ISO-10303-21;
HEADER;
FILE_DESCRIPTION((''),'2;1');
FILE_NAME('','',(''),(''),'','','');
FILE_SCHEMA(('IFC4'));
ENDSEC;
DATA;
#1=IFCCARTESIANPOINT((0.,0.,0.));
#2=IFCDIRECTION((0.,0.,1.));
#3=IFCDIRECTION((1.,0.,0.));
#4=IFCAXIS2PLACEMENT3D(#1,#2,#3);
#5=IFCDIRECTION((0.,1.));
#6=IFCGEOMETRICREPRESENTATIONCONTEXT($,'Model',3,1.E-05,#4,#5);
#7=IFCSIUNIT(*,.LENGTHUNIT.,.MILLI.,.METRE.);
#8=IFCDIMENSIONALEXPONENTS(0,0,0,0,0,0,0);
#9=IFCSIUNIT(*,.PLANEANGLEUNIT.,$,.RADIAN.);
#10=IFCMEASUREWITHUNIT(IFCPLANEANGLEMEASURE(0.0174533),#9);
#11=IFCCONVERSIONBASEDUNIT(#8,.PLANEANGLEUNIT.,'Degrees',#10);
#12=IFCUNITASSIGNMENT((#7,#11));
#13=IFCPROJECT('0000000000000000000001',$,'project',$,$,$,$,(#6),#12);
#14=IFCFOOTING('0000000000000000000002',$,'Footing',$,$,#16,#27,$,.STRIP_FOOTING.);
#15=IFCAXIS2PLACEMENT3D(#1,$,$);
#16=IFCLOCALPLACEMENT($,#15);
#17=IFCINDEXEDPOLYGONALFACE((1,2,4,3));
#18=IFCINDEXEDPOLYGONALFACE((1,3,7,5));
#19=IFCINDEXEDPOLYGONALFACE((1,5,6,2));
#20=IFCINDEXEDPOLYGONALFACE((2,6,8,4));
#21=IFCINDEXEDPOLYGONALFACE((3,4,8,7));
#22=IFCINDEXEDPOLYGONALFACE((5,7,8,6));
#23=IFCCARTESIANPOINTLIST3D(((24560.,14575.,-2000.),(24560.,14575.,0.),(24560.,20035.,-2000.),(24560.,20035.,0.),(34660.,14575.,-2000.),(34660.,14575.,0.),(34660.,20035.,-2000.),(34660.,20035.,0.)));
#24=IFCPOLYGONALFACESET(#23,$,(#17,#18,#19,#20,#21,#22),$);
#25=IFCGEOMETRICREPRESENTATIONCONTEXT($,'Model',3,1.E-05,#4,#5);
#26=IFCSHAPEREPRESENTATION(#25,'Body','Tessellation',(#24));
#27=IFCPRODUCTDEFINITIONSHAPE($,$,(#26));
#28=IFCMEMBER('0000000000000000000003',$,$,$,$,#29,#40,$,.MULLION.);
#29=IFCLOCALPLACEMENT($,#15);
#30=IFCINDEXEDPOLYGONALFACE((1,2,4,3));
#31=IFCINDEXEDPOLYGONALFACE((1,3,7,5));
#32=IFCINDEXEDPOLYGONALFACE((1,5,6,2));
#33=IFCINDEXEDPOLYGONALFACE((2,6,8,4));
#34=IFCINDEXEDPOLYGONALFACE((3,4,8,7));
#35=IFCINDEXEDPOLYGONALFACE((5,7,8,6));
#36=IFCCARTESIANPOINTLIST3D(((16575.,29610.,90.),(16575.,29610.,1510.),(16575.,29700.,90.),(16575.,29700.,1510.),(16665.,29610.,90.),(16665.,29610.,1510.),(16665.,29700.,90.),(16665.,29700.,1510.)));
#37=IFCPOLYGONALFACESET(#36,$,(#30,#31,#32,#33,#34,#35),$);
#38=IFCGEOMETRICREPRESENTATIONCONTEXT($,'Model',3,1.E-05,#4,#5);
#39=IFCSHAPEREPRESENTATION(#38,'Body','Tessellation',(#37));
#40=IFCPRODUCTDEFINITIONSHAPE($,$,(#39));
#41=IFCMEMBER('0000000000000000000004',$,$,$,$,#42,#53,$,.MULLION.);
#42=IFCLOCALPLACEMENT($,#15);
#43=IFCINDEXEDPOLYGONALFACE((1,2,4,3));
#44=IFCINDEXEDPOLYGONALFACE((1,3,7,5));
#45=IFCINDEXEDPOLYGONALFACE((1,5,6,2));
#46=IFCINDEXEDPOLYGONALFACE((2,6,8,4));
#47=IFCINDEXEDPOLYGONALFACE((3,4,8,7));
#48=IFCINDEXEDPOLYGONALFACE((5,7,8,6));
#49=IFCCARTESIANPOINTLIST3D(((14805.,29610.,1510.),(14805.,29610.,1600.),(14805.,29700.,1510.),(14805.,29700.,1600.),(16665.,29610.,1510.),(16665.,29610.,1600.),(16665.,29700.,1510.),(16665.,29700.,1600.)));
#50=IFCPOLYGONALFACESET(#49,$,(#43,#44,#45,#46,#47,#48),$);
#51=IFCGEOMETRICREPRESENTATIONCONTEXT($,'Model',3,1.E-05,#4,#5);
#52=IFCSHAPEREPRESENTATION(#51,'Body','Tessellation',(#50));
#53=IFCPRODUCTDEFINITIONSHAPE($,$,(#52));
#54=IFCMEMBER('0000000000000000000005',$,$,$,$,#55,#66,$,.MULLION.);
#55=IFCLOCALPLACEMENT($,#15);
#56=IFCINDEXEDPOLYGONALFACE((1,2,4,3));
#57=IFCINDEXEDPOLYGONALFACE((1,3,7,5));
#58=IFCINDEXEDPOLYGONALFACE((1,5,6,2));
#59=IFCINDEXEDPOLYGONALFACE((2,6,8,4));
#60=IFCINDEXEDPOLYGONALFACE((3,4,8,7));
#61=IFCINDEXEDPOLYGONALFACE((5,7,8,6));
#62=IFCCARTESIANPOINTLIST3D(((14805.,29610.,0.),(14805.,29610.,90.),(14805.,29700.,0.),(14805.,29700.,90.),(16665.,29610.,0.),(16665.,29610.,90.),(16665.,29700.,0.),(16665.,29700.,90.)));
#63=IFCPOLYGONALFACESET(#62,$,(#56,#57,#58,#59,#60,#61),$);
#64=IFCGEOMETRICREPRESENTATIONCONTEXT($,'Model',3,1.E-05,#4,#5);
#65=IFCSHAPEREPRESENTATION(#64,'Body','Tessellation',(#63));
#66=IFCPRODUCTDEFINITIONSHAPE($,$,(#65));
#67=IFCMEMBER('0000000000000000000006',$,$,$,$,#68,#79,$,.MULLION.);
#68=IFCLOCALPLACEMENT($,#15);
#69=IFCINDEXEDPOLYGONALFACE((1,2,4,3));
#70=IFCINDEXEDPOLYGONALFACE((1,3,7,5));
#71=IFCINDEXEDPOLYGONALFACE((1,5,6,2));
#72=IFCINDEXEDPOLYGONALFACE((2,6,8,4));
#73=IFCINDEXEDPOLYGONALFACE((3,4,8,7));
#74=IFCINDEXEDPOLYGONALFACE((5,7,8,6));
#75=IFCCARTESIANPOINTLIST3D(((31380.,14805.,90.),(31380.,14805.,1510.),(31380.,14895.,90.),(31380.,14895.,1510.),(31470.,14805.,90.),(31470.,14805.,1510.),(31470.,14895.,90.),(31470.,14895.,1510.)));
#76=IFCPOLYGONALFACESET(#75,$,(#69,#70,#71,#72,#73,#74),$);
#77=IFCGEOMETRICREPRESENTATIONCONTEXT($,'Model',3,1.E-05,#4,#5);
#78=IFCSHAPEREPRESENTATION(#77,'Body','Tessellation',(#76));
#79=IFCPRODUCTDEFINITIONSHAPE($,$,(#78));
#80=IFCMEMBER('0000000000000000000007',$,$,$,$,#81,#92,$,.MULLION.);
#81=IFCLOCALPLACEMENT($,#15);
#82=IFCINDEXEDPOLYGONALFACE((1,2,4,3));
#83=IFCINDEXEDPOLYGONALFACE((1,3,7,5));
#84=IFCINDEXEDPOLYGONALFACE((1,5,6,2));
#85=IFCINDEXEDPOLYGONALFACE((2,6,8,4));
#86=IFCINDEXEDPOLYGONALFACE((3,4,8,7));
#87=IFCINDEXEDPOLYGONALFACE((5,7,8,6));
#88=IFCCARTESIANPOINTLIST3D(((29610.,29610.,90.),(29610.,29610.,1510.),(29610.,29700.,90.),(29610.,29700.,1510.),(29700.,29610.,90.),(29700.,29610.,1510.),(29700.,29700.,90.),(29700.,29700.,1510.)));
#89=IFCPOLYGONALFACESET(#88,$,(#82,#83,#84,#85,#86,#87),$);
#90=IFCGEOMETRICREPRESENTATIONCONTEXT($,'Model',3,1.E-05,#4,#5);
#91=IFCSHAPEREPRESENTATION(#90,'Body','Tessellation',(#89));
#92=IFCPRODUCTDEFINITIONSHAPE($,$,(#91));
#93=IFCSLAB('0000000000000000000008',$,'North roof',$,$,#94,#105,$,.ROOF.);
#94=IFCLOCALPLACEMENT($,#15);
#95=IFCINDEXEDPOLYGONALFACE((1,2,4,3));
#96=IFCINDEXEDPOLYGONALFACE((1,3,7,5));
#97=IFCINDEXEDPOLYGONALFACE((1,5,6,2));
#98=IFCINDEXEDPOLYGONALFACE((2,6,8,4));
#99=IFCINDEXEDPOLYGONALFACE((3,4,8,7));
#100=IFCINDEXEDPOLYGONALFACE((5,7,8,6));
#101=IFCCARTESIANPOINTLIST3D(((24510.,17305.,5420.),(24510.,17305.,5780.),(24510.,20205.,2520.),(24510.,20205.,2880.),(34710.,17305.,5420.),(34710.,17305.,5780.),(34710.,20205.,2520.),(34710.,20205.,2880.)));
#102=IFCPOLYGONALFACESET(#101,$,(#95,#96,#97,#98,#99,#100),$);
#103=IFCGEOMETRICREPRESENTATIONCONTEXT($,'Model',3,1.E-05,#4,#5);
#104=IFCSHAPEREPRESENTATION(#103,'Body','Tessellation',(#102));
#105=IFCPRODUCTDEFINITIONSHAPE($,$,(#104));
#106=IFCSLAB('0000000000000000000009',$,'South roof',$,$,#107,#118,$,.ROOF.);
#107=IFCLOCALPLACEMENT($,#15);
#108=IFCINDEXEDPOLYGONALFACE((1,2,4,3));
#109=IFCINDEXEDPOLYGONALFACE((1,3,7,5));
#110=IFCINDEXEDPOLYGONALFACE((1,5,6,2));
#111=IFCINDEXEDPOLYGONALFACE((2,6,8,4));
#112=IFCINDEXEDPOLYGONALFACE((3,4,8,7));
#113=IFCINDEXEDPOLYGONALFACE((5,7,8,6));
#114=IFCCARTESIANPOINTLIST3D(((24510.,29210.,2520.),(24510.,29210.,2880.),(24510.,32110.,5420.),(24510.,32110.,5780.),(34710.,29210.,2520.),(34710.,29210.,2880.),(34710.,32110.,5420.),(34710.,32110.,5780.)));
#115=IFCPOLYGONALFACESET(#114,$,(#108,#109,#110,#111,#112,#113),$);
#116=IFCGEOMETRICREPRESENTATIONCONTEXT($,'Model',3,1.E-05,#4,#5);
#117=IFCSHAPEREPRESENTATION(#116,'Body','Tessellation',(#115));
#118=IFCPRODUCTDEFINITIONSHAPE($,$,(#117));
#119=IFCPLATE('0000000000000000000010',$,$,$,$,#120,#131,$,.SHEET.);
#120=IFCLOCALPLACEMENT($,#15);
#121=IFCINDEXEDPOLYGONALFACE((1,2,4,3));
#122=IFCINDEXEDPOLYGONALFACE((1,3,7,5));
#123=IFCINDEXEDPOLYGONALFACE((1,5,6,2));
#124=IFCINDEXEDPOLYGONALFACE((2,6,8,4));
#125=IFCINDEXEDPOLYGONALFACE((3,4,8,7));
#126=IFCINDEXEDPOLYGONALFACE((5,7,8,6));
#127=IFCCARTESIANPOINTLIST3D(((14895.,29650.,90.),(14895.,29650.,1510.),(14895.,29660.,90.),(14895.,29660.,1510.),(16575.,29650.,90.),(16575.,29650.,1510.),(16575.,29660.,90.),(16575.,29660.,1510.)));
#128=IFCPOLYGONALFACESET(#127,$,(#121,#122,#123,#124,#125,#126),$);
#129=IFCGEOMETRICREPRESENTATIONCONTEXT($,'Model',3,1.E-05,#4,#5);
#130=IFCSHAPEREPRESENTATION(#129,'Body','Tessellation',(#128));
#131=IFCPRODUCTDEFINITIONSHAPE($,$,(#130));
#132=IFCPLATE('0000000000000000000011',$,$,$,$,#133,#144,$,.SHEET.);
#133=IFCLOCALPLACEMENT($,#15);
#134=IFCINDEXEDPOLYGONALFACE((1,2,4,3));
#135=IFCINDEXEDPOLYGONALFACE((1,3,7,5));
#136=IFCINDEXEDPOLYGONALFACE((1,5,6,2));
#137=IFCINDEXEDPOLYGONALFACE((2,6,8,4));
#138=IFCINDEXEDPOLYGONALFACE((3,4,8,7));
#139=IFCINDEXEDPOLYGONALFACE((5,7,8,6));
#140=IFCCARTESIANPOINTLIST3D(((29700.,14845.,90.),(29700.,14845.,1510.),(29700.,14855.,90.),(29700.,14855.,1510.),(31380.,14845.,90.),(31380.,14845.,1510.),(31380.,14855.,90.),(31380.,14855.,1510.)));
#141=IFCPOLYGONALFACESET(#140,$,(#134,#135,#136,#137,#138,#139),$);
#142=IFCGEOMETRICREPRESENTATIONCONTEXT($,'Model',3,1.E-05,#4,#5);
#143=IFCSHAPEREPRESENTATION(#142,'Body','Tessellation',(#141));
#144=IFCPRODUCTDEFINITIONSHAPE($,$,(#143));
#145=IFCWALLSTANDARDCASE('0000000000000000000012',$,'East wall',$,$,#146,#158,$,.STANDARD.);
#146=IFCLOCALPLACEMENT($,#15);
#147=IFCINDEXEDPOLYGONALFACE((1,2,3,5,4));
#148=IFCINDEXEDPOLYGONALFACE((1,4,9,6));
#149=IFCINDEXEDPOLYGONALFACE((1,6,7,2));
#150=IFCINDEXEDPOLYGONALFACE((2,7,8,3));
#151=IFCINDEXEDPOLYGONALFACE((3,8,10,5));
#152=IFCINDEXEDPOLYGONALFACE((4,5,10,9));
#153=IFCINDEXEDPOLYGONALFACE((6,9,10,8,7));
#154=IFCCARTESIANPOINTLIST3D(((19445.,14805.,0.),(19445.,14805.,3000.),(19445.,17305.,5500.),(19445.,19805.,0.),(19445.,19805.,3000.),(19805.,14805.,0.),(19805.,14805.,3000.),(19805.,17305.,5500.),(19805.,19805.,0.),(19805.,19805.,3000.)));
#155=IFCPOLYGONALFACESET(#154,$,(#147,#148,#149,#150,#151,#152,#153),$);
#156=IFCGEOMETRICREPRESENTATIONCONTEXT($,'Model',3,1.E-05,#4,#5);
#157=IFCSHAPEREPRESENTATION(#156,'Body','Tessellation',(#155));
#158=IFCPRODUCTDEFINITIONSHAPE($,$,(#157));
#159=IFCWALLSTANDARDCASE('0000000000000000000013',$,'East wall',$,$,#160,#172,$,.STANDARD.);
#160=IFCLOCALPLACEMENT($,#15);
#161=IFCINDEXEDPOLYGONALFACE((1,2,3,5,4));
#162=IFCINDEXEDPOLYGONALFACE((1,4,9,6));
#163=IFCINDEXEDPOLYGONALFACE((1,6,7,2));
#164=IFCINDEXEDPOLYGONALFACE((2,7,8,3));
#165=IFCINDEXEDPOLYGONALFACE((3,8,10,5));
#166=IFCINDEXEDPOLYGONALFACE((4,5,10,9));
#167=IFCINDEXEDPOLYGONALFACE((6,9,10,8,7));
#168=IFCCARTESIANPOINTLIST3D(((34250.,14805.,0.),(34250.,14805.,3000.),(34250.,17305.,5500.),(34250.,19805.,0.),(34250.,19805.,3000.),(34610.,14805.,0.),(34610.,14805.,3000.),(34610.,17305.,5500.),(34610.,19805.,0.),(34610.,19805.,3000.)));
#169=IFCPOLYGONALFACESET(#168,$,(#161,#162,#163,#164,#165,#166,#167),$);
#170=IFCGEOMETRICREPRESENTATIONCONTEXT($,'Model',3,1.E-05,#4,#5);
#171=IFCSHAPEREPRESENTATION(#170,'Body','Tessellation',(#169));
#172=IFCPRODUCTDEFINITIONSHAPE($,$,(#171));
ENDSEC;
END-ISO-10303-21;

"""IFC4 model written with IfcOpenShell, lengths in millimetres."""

from ifc_helpers import new_model, entity, si_unit, converted_unit, direction, frame, origin_with_axes, place, context, project, polyline, outline, extrude, clip, halfspace, source, transform, mapped, element, save


model = new_model("IFC4")

# Units and contexts
model_context_1 = context("Model", 3, precision=1e-05, world=origin_with_axes(), true_north=direction((0.0, 1.0)))
model_context_2 = context("Model", 3, precision=1e-05, world=origin_with_axes(), true_north=direction((0.0, 1.0)))
model_context_3 = context("Model", 3, precision=1e-05, world=origin_with_axes(), true_north=direction((0.0, 1.0)))
model_context_4 = context("Model", 3, precision=1e-05, world=origin_with_axes(), true_north=direction((0.0, 1.0)))
model_context_5 = context("Model", 3, precision=1e-05, world=origin_with_axes(), true_north=direction((0.0, 1.0)))
model_context_6 = context("Model", 3, precision=1e-05, world=origin_with_axes(), true_north=direction((0.0, 1.0)))
model_context_7 = context("Model", 3, precision=1e-05, world=origin_with_axes(), true_north=direction((0.0, 1.0)))
model_context_8 = context("Model", 3, precision=1e-05, world=origin_with_axes(), true_north=direction((0.0, 1.0)))
model_context_9 = context("Model", 3, precision=1e-05, world=origin_with_axes(), true_north=direction((0.0, 1.0)))
model_context_10 = context("Model", 3, precision=1e-05, world=origin_with_axes(), true_north=direction((0.0, 1.0)))
model_context_11 = context("Model", 3, precision=1e-05, world=origin_with_axes(), true_north=direction((0.0, 1.0)))
model_context_12 = context("Model", 3, precision=1e-05, world=origin_with_axes(), true_north=direction((0.0, 1.0)))
model_context_13 = context("Model", 3, precision=1e-05, world=origin_with_axes(), true_north=direction((0.0, 1.0)))
ifc_project = project(units=[si_unit("LENGTHUNIT", "METRE", prefix="MILLI"), converted_unit("PLANEANGLEUNIT", "Degrees", entity("IfcPlaneAngleMeasure", 0.0174533), si_unit("PLANEANGLEUNIT", "RADIAN"), dimensions=[0, 0, 0, 0, 0, 0, 0])], contexts=[model_context_1])

# Footing
placement_1 = place(None, frame((29610.0, 14805.0, 0.0)))
footing_placement = place(placement_1, frame((0.0, 2500.0, -2000.0), z_axis=(0.0, 0.0, 1.0), x_axis=(1.0, 0.0, 0.0)))
element("IfcFooting", 1, at=footing_placement, Name="Footing", PredefinedType="STRIP_FOOTING", context=model_context_7, shape_type="SweptSolid", body=[
    extrude(outline(polyline([(-5050.0, -2730.0), (5050.0, -2730.0), (5050.0, 2730.0), (-5050.0, 2730.0), (-5050.0, -2730.0), (-5050.0, -2730.0)])), origin_with_axes(), (0.0, 0.0, 1.0), 2000.0),
])

# Members
shared_shape_1 = source(origin_with_axes(), model_context_3, "Body", "SweptSolid", [
    extrude(outline(polyline([(-45.0, -45.0), (45.0, -45.0), (45.0, 45.0), (-45.0, 45.0), (-45.0, -45.0), (-45.0, -45.0)])), origin_with_axes(), (0.0, 0.0, 1.0), 1420.0),
])
placement_2 = place(None, frame((14805.0, 29610.0, 0.0)))
member_1_placement = place(placement_2, frame((1815.0, 45.0, 90.0), z_axis=(0.0, 0.0, 1.0), x_axis=(1.0, 0.0, 0.0)))
element("IfcMember", 2, at=member_1_placement, PredefinedType="MULLION", context=model_context_3, shape_type="MappedRepresentation", body=[
    mapped(shared_shape_1, transform((0.0, 0.0, 0.0))),
])
shared_shape_2 = source(origin_with_axes(), model_context_4, "Body", "SweptSolid", [
    extrude(outline(polyline([(-930.0, -45.0), (930.0, -45.0), (930.0, 45.0), (-930.0, 45.0), (-930.0, -45.0), (-930.0, -45.0)])), origin_with_axes(), (0.0, 0.0, 1.0), 90.0),
])
member_2_placement = place(placement_2, frame((930.0, 45.0, 1510.0), z_axis=(0.0, 0.0, 1.0), x_axis=(1.0, 0.0, 0.0)))
element("IfcMember", 3, at=member_2_placement, PredefinedType="MULLION", context=model_context_4, shape_type="MappedRepresentation", body=[
    mapped(shared_shape_2, transform((0.0, 0.0, 0.0))),
])
shared_shape_3 = source(origin_with_axes(), model_context_5, "Body", "SweptSolid", [
    extrude(outline(polyline([(-930.0, -45.0), (930.0, -45.0), (930.0, 45.0), (-930.0, 45.0), (-930.0, -45.0), (-930.0, -45.0)])), origin_with_axes(), (0.0, 0.0, 1.0), 90.0),
])
member_3_placement = place(placement_2, frame((930.0, 45.0, 0.0), z_axis=(0.0, 0.0, 1.0), x_axis=(1.0, 0.0, 0.0)))
element("IfcMember", 4, at=member_3_placement, PredefinedType="MULLION", context=model_context_5, shape_type="MappedRepresentation", body=[
    mapped(shared_shape_3, transform((0.0, 0.0, 0.0))),
])
shared_shape_4 = source(origin_with_axes(), model_context_8, "Body", "SweptSolid", [
    extrude(outline(polyline([(-45.0, -45.0), (45.0, -45.0), (45.0, 45.0), (-45.0, 45.0), (-45.0, -45.0), (-45.0, -45.0)])), origin_with_axes(), (0.0, 0.0, 1.0), 1420.0),
])
member_4_placement = place(placement_1, frame((1815.0, 45.0, 90.0), z_axis=(0.0, 0.0, 1.0), x_axis=(1.0, 0.0, 0.0)))
element("IfcMember", 5, at=member_4_placement, PredefinedType="MULLION", context=model_context_8, shape_type="MappedRepresentation", body=[
    mapped(shared_shape_4, transform((0.0, 0.0, 0.0))),
])
shared_shape_5 = source(origin_with_axes(), model_context_12, "Body", "SweptSolid", [
    extrude(outline(polyline([(-45.0, -45.0), (45.0, -45.0), (45.0, 45.0), (-45.0, 45.0), (-45.0, -45.0), (-45.0, -45.0)])), origin_with_axes(), (0.0, 0.0, 1.0), 1420.0),
])
placement_3 = place(None, frame((29610.0, 29610.0, 0.0)))
member_5_placement = place(placement_3, frame((45.0, 45.0, 90.0), z_axis=(0.0, 0.0, 1.0), x_axis=(1.0, 0.0, 0.0)))
element("IfcMember", 6, at=member_5_placement, PredefinedType="MULLION", context=model_context_12, shape_type="MappedRepresentation", body=[
    mapped(shared_shape_5, transform((0.0, 0.0, 0.0))),
])

# Slabs
shared_shape_6 = source(origin_with_axes(), model_context_10, "Body", "SweptSolid", [
    extrude(outline(polyline([(-5100.0, -180.0), (5100.0, -180.0), (5100.0, 180.0), (-5100.0, 180.0), (-5100.0, -180.0), (-5100.0, -180.0)])), frame((0.0, 0.0, 0.0), z_axis=(0.0, 1.0, 0.0), x_axis=(1.0, 0.0, 0.0)), (0.0, -0.707107, 0.707107), 4101.2),
])
slab_1_placement = place(placement_1, frame((0.0, 5400.0, 2700.0), z_axis=(0.0, 0.0, 1.0), x_axis=(-1.0, 0.0, 0.0)))
element("IfcSlab", 7, at=slab_1_placement, Name="North roof", PredefinedType="ROOF", context=model_context_10, shape_type="MappedRepresentation", body=[
    mapped(shared_shape_6, transform((0.0, 0.0, 0.0))),
])
shared_shape_7 = source(origin_with_axes(), model_context_13, "Body", "SweptSolid", [
    extrude(outline(polyline([(-5100.0, -180.0), (5100.0, -180.0), (5100.0, 180.0), (-5100.0, 180.0), (-5100.0, -180.0), (-5100.0, -180.0)])), frame((0.0, 0.0, 0.0), z_axis=(0.0, 1.0, 0.0), x_axis=(1.0, 0.0, 0.0)), (0.0, -0.707107, 0.707107), 4101.2),
])
slab_2_placement = place(placement_3, frame((0.0, -400.0, 2700.0), z_axis=(0.0, 0.0, 1.0), x_axis=(1.0, 0.0, 0.0)))
element("IfcSlab", 8, at=slab_2_placement, Name="South roof", PredefinedType="ROOF", context=model_context_13, shape_type="MappedRepresentation", body=[
    mapped(shared_shape_7, transform((0.0, 0.0, 0.0))),
])

# Plates
plate_1_placement = place(placement_2, frame((930.0, 45.0, 90.0), z_axis=(0.0, 0.0, 1.0), x_axis=(1.0, 0.0, 0.0)))
element("IfcPlate", 9, at=plate_1_placement, PredefinedType="SHEET", context=model_context_6, shape_type="SweptSolid", body=[
    extrude(outline(polyline([(-840.0, -5.0), (840.0, -5.0), (840.0, 5.0), (-840.0, 5.0), (-840.0, -5.0), (-840.0, -5.0)])), origin_with_axes(), (0.0, 0.0, 1.0), 1420.0),
])
plate_2_placement = place(placement_1, frame((930.0, 45.0, 90.0), z_axis=(0.0, 0.0, 1.0), x_axis=(1.0, 0.0, 0.0)))
element("IfcPlate", 10, at=plate_2_placement, PredefinedType="SHEET", context=model_context_9, shape_type="SweptSolid", body=[
    extrude(outline(polyline([(-840.0, -5.0), (840.0, -5.0), (840.0, 5.0), (-840.0, 5.0), (-840.0, -5.0), (-840.0, -5.0)])), origin_with_axes(), (0.0, 0.0, 1.0), 1420.0),
])

# Walls
shared_shape_8 = source(origin_with_axes(), model_context_2, "Body", "Clipping", [
    clip(clip(extrude(outline(polyline([(-2500.0, -180.0), (2500.0, -180.0), (2500.0, 180.0), (-2500.0, 180.0), (-2500.0, -180.0), (-2500.0, -180.0)])), origin_with_axes(), (0.0, 0.0, 1.0), 6000.0), halfspace(frame((-2500.0, 0.0, 3000.0), z_axis=(-1.0, 0.0, 1.0), x_axis=(1.0, 0.0, 0.0)), False)), halfspace(frame((2500.0, 0.0, 3000.0), z_axis=(1.0, 0.0, 1.0), x_axis=(1.0, 0.0, 0.0)), False)),
])
placement_4 = place(None, frame((14805.0, 14805.0, 0.0)))
wall_1_placement = place(placement_4, frame((4820.0, 2500.0, 0.0), z_axis=(0.0, 0.0, 1.0), x_axis=(0.0, 1.0, 0.0)))
element("IfcWallStandardCase", 11, at=wall_1_placement, Name="East wall", PredefinedType="STANDARD", context=model_context_2, shape_type="MappedRepresentation", body=[
    mapped(shared_shape_8, transform((0.0, 0.0, 0.0))),
])
shared_shape_9 = source(origin_with_axes(), model_context_11, "Body", "Clipping", [
    clip(clip(extrude(outline(polyline([(-2500.0, -180.0), (2500.0, -180.0), (2500.0, 180.0), (-2500.0, 180.0), (-2500.0, -180.0), (-2500.0, -180.0)])), origin_with_axes(), (0.0, 0.0, 1.0), 6000.0), halfspace(frame((-2500.0, 0.0, 3000.0), z_axis=(-1.0, 0.0, 1.0), x_axis=(1.0, 0.0, 0.0)), False)), halfspace(frame((2500.0, 0.0, 3000.0), z_axis=(1.0, 0.0, 1.0), x_axis=(1.0, 0.0, 0.0)), False)),
])
wall_2_placement = place(placement_1, frame((4820.0, 2500.0, 0.0), z_axis=(0.0, 0.0, 1.0), x_axis=(0.0, 1.0, 0.0)))
element("IfcWallStandardCase", 12, at=wall_2_placement, Name="East wall", PredefinedType="STANDARD", context=model_context_11, shape_type="MappedRepresentation", body=[
    mapped(shared_shape_9, transform((0.0, 0.0, 0.0))),
])

save(model, "model.ifc")
